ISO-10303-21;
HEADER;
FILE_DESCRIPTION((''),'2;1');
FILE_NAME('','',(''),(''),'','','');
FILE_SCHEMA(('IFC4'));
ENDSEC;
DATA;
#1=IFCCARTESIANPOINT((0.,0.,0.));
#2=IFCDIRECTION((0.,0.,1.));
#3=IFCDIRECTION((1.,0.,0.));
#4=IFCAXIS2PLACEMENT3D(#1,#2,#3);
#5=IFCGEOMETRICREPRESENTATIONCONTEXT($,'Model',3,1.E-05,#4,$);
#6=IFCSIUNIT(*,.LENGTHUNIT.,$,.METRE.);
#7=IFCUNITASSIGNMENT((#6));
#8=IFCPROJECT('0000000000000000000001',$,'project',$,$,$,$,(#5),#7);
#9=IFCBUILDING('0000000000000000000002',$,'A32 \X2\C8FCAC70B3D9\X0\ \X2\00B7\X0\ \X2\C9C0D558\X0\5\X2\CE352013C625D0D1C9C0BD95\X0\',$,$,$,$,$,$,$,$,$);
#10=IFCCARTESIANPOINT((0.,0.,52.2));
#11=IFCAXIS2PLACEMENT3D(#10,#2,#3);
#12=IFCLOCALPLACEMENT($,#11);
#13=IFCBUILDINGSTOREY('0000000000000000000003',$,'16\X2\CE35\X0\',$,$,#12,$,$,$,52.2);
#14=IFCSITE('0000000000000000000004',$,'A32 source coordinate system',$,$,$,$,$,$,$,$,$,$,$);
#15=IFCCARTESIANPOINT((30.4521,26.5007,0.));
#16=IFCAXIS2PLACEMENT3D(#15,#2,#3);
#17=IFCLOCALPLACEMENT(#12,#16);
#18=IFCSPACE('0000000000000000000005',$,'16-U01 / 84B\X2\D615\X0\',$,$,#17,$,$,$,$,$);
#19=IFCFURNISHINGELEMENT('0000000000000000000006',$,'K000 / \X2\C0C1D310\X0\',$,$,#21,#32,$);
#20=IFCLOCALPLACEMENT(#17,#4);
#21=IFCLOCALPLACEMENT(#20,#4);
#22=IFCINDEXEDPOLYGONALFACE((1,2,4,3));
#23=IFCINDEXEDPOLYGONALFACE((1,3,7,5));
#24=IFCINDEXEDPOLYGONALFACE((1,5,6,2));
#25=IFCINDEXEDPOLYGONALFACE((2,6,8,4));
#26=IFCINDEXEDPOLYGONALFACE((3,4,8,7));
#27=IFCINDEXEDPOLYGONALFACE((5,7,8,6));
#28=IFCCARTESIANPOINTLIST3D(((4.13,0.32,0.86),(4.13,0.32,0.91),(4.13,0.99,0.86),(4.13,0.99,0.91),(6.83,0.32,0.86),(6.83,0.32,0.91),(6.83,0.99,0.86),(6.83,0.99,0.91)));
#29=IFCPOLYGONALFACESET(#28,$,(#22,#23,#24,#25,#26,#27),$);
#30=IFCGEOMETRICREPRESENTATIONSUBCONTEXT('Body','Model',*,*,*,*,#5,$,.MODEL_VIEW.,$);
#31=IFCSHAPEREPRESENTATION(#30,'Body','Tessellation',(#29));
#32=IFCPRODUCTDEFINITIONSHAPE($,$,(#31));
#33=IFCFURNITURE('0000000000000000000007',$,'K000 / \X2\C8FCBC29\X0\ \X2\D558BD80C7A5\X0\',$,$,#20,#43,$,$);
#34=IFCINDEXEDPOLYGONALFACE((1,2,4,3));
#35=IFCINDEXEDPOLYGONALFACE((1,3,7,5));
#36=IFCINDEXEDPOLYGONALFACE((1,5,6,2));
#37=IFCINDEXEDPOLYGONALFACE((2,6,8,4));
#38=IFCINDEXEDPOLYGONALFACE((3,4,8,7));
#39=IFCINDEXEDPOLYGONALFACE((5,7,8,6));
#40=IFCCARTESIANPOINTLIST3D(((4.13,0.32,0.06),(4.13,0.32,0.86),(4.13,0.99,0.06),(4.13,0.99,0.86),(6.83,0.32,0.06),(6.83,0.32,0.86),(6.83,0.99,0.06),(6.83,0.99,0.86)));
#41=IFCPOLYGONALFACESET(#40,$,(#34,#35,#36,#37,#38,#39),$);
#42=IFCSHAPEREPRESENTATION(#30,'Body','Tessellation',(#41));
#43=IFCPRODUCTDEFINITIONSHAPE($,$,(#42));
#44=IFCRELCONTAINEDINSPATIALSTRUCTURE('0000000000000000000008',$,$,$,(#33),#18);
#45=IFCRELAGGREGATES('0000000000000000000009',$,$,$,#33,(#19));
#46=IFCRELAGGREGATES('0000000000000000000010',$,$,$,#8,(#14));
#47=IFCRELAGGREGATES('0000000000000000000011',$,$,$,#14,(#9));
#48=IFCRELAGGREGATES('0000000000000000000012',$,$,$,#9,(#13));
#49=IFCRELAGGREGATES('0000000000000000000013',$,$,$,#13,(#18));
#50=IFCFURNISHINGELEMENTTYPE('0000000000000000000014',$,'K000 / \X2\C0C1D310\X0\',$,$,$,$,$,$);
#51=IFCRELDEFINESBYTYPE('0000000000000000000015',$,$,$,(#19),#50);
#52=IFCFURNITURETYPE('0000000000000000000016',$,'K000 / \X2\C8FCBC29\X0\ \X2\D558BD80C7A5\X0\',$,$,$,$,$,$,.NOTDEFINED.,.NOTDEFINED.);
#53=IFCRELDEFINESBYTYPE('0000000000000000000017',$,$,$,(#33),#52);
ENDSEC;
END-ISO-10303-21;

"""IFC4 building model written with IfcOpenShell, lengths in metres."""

from ifc_helpers import new_model, si_unit, frame, origin, origin_with_axes, place, context, subcontext, project, spatial, polyline, outline, extrude, source, transform, mapped, type_object, type_shapes, element, aggregate, save


model = new_model("IFC4")

# Units and contexts
model_context = context("Model", 3, precision=1e-05, world=origin_with_axes())
body_context = subcontext(model_context, "Body", "Model", "MODEL_VIEW")
ifc_project = project(units=[si_unit("LENGTHUNIT", "METRE")], contexts=[model_context])

# Site, building, storey, space
site = spatial("IfcSite", under=ifc_project, Name="A32 source coordinate system")
building = spatial("IfcBuilding", under=site, Name="A32 주거동 · 지하5층–옥탑지붕")
storey_placement = place(None, frame((0.0, 0.0, 52.2), z_axis=(0.0, 0.0, 1.0), x_axis=(1.0, 0.0, 0.0)))
storey = spatial("IfcBuildingStorey", under=building, at=storey_placement, Name="16층", Elevation=52.2)
space_placement = place(storey_placement, frame((30.4521, 26.5007, 0.0), z_axis=(0.0, 0.0, 1.0), x_axis=(1.0, 0.0, 0.0)))
space = spatial("IfcSpace", under=storey, at=space_placement, Name="16-U01 / 84B형")

# Furnishing element
furnishing_element_type = type_object("IfcFurnishingElementType", Name="K000 / 상판")
shared_shape_1 = source(origin(), body_context, "Body", "SweptSolid", [
    extrude(outline(polyline([(4.13, 0.32), (4.13, 0.99), (6.83, 0.99), (6.83, 0.32), (4.13, 0.32)])), frame((0.0, 0.0, 0.86)), (0.0, 0.0, 1.0), 0.05),
])
type_shapes(furnishing_element_type, [shared_shape_1])
furniture_placement = place(space_placement, origin_with_axes())
furnishing_placement = place(furniture_placement, origin_with_axes())
furnishing = element("IfcFurnishingElement", 1, at=furnishing_placement, type_object=furnishing_element_type, Name="K000 / 상판", context=body_context, shape_type="MappedRepresentation", body=[
    mapped(shared_shape_1, transform((0.0, 0.0, 0.0), scale=1.0)),
])

# Furniture
furniture_type = type_object("IfcFurnitureType", Name="K000 / 주방 하부장", AssemblyPlace="NOTDEFINED", PredefinedType="NOTDEFINED")
shared_shape_2 = source(origin(), body_context, "Body", "SweptSolid", [
    extrude(outline(polyline([(6.83, 0.32), (4.13, 0.32), (4.13, 0.99), (6.83, 0.99), (6.83, 0.32)])), frame((0.0, 0.0, 0.06)), (0.0, 0.0, 1.0), 0.8),
])
type_shapes(furniture_type, [shared_shape_2])
furniture = element("IfcFurniture", 2, at=furniture_placement, inside=space, type_object=furniture_type, Name="K000 / 주방 하부장", context=body_context, shape_type="MappedRepresentation", body=[
    mapped(shared_shape_2, transform((0.0, 0.0, 0.0), scale=1.0)),
])
aggregate(furniture, [furnishing])

save(model, "model.ifc")
